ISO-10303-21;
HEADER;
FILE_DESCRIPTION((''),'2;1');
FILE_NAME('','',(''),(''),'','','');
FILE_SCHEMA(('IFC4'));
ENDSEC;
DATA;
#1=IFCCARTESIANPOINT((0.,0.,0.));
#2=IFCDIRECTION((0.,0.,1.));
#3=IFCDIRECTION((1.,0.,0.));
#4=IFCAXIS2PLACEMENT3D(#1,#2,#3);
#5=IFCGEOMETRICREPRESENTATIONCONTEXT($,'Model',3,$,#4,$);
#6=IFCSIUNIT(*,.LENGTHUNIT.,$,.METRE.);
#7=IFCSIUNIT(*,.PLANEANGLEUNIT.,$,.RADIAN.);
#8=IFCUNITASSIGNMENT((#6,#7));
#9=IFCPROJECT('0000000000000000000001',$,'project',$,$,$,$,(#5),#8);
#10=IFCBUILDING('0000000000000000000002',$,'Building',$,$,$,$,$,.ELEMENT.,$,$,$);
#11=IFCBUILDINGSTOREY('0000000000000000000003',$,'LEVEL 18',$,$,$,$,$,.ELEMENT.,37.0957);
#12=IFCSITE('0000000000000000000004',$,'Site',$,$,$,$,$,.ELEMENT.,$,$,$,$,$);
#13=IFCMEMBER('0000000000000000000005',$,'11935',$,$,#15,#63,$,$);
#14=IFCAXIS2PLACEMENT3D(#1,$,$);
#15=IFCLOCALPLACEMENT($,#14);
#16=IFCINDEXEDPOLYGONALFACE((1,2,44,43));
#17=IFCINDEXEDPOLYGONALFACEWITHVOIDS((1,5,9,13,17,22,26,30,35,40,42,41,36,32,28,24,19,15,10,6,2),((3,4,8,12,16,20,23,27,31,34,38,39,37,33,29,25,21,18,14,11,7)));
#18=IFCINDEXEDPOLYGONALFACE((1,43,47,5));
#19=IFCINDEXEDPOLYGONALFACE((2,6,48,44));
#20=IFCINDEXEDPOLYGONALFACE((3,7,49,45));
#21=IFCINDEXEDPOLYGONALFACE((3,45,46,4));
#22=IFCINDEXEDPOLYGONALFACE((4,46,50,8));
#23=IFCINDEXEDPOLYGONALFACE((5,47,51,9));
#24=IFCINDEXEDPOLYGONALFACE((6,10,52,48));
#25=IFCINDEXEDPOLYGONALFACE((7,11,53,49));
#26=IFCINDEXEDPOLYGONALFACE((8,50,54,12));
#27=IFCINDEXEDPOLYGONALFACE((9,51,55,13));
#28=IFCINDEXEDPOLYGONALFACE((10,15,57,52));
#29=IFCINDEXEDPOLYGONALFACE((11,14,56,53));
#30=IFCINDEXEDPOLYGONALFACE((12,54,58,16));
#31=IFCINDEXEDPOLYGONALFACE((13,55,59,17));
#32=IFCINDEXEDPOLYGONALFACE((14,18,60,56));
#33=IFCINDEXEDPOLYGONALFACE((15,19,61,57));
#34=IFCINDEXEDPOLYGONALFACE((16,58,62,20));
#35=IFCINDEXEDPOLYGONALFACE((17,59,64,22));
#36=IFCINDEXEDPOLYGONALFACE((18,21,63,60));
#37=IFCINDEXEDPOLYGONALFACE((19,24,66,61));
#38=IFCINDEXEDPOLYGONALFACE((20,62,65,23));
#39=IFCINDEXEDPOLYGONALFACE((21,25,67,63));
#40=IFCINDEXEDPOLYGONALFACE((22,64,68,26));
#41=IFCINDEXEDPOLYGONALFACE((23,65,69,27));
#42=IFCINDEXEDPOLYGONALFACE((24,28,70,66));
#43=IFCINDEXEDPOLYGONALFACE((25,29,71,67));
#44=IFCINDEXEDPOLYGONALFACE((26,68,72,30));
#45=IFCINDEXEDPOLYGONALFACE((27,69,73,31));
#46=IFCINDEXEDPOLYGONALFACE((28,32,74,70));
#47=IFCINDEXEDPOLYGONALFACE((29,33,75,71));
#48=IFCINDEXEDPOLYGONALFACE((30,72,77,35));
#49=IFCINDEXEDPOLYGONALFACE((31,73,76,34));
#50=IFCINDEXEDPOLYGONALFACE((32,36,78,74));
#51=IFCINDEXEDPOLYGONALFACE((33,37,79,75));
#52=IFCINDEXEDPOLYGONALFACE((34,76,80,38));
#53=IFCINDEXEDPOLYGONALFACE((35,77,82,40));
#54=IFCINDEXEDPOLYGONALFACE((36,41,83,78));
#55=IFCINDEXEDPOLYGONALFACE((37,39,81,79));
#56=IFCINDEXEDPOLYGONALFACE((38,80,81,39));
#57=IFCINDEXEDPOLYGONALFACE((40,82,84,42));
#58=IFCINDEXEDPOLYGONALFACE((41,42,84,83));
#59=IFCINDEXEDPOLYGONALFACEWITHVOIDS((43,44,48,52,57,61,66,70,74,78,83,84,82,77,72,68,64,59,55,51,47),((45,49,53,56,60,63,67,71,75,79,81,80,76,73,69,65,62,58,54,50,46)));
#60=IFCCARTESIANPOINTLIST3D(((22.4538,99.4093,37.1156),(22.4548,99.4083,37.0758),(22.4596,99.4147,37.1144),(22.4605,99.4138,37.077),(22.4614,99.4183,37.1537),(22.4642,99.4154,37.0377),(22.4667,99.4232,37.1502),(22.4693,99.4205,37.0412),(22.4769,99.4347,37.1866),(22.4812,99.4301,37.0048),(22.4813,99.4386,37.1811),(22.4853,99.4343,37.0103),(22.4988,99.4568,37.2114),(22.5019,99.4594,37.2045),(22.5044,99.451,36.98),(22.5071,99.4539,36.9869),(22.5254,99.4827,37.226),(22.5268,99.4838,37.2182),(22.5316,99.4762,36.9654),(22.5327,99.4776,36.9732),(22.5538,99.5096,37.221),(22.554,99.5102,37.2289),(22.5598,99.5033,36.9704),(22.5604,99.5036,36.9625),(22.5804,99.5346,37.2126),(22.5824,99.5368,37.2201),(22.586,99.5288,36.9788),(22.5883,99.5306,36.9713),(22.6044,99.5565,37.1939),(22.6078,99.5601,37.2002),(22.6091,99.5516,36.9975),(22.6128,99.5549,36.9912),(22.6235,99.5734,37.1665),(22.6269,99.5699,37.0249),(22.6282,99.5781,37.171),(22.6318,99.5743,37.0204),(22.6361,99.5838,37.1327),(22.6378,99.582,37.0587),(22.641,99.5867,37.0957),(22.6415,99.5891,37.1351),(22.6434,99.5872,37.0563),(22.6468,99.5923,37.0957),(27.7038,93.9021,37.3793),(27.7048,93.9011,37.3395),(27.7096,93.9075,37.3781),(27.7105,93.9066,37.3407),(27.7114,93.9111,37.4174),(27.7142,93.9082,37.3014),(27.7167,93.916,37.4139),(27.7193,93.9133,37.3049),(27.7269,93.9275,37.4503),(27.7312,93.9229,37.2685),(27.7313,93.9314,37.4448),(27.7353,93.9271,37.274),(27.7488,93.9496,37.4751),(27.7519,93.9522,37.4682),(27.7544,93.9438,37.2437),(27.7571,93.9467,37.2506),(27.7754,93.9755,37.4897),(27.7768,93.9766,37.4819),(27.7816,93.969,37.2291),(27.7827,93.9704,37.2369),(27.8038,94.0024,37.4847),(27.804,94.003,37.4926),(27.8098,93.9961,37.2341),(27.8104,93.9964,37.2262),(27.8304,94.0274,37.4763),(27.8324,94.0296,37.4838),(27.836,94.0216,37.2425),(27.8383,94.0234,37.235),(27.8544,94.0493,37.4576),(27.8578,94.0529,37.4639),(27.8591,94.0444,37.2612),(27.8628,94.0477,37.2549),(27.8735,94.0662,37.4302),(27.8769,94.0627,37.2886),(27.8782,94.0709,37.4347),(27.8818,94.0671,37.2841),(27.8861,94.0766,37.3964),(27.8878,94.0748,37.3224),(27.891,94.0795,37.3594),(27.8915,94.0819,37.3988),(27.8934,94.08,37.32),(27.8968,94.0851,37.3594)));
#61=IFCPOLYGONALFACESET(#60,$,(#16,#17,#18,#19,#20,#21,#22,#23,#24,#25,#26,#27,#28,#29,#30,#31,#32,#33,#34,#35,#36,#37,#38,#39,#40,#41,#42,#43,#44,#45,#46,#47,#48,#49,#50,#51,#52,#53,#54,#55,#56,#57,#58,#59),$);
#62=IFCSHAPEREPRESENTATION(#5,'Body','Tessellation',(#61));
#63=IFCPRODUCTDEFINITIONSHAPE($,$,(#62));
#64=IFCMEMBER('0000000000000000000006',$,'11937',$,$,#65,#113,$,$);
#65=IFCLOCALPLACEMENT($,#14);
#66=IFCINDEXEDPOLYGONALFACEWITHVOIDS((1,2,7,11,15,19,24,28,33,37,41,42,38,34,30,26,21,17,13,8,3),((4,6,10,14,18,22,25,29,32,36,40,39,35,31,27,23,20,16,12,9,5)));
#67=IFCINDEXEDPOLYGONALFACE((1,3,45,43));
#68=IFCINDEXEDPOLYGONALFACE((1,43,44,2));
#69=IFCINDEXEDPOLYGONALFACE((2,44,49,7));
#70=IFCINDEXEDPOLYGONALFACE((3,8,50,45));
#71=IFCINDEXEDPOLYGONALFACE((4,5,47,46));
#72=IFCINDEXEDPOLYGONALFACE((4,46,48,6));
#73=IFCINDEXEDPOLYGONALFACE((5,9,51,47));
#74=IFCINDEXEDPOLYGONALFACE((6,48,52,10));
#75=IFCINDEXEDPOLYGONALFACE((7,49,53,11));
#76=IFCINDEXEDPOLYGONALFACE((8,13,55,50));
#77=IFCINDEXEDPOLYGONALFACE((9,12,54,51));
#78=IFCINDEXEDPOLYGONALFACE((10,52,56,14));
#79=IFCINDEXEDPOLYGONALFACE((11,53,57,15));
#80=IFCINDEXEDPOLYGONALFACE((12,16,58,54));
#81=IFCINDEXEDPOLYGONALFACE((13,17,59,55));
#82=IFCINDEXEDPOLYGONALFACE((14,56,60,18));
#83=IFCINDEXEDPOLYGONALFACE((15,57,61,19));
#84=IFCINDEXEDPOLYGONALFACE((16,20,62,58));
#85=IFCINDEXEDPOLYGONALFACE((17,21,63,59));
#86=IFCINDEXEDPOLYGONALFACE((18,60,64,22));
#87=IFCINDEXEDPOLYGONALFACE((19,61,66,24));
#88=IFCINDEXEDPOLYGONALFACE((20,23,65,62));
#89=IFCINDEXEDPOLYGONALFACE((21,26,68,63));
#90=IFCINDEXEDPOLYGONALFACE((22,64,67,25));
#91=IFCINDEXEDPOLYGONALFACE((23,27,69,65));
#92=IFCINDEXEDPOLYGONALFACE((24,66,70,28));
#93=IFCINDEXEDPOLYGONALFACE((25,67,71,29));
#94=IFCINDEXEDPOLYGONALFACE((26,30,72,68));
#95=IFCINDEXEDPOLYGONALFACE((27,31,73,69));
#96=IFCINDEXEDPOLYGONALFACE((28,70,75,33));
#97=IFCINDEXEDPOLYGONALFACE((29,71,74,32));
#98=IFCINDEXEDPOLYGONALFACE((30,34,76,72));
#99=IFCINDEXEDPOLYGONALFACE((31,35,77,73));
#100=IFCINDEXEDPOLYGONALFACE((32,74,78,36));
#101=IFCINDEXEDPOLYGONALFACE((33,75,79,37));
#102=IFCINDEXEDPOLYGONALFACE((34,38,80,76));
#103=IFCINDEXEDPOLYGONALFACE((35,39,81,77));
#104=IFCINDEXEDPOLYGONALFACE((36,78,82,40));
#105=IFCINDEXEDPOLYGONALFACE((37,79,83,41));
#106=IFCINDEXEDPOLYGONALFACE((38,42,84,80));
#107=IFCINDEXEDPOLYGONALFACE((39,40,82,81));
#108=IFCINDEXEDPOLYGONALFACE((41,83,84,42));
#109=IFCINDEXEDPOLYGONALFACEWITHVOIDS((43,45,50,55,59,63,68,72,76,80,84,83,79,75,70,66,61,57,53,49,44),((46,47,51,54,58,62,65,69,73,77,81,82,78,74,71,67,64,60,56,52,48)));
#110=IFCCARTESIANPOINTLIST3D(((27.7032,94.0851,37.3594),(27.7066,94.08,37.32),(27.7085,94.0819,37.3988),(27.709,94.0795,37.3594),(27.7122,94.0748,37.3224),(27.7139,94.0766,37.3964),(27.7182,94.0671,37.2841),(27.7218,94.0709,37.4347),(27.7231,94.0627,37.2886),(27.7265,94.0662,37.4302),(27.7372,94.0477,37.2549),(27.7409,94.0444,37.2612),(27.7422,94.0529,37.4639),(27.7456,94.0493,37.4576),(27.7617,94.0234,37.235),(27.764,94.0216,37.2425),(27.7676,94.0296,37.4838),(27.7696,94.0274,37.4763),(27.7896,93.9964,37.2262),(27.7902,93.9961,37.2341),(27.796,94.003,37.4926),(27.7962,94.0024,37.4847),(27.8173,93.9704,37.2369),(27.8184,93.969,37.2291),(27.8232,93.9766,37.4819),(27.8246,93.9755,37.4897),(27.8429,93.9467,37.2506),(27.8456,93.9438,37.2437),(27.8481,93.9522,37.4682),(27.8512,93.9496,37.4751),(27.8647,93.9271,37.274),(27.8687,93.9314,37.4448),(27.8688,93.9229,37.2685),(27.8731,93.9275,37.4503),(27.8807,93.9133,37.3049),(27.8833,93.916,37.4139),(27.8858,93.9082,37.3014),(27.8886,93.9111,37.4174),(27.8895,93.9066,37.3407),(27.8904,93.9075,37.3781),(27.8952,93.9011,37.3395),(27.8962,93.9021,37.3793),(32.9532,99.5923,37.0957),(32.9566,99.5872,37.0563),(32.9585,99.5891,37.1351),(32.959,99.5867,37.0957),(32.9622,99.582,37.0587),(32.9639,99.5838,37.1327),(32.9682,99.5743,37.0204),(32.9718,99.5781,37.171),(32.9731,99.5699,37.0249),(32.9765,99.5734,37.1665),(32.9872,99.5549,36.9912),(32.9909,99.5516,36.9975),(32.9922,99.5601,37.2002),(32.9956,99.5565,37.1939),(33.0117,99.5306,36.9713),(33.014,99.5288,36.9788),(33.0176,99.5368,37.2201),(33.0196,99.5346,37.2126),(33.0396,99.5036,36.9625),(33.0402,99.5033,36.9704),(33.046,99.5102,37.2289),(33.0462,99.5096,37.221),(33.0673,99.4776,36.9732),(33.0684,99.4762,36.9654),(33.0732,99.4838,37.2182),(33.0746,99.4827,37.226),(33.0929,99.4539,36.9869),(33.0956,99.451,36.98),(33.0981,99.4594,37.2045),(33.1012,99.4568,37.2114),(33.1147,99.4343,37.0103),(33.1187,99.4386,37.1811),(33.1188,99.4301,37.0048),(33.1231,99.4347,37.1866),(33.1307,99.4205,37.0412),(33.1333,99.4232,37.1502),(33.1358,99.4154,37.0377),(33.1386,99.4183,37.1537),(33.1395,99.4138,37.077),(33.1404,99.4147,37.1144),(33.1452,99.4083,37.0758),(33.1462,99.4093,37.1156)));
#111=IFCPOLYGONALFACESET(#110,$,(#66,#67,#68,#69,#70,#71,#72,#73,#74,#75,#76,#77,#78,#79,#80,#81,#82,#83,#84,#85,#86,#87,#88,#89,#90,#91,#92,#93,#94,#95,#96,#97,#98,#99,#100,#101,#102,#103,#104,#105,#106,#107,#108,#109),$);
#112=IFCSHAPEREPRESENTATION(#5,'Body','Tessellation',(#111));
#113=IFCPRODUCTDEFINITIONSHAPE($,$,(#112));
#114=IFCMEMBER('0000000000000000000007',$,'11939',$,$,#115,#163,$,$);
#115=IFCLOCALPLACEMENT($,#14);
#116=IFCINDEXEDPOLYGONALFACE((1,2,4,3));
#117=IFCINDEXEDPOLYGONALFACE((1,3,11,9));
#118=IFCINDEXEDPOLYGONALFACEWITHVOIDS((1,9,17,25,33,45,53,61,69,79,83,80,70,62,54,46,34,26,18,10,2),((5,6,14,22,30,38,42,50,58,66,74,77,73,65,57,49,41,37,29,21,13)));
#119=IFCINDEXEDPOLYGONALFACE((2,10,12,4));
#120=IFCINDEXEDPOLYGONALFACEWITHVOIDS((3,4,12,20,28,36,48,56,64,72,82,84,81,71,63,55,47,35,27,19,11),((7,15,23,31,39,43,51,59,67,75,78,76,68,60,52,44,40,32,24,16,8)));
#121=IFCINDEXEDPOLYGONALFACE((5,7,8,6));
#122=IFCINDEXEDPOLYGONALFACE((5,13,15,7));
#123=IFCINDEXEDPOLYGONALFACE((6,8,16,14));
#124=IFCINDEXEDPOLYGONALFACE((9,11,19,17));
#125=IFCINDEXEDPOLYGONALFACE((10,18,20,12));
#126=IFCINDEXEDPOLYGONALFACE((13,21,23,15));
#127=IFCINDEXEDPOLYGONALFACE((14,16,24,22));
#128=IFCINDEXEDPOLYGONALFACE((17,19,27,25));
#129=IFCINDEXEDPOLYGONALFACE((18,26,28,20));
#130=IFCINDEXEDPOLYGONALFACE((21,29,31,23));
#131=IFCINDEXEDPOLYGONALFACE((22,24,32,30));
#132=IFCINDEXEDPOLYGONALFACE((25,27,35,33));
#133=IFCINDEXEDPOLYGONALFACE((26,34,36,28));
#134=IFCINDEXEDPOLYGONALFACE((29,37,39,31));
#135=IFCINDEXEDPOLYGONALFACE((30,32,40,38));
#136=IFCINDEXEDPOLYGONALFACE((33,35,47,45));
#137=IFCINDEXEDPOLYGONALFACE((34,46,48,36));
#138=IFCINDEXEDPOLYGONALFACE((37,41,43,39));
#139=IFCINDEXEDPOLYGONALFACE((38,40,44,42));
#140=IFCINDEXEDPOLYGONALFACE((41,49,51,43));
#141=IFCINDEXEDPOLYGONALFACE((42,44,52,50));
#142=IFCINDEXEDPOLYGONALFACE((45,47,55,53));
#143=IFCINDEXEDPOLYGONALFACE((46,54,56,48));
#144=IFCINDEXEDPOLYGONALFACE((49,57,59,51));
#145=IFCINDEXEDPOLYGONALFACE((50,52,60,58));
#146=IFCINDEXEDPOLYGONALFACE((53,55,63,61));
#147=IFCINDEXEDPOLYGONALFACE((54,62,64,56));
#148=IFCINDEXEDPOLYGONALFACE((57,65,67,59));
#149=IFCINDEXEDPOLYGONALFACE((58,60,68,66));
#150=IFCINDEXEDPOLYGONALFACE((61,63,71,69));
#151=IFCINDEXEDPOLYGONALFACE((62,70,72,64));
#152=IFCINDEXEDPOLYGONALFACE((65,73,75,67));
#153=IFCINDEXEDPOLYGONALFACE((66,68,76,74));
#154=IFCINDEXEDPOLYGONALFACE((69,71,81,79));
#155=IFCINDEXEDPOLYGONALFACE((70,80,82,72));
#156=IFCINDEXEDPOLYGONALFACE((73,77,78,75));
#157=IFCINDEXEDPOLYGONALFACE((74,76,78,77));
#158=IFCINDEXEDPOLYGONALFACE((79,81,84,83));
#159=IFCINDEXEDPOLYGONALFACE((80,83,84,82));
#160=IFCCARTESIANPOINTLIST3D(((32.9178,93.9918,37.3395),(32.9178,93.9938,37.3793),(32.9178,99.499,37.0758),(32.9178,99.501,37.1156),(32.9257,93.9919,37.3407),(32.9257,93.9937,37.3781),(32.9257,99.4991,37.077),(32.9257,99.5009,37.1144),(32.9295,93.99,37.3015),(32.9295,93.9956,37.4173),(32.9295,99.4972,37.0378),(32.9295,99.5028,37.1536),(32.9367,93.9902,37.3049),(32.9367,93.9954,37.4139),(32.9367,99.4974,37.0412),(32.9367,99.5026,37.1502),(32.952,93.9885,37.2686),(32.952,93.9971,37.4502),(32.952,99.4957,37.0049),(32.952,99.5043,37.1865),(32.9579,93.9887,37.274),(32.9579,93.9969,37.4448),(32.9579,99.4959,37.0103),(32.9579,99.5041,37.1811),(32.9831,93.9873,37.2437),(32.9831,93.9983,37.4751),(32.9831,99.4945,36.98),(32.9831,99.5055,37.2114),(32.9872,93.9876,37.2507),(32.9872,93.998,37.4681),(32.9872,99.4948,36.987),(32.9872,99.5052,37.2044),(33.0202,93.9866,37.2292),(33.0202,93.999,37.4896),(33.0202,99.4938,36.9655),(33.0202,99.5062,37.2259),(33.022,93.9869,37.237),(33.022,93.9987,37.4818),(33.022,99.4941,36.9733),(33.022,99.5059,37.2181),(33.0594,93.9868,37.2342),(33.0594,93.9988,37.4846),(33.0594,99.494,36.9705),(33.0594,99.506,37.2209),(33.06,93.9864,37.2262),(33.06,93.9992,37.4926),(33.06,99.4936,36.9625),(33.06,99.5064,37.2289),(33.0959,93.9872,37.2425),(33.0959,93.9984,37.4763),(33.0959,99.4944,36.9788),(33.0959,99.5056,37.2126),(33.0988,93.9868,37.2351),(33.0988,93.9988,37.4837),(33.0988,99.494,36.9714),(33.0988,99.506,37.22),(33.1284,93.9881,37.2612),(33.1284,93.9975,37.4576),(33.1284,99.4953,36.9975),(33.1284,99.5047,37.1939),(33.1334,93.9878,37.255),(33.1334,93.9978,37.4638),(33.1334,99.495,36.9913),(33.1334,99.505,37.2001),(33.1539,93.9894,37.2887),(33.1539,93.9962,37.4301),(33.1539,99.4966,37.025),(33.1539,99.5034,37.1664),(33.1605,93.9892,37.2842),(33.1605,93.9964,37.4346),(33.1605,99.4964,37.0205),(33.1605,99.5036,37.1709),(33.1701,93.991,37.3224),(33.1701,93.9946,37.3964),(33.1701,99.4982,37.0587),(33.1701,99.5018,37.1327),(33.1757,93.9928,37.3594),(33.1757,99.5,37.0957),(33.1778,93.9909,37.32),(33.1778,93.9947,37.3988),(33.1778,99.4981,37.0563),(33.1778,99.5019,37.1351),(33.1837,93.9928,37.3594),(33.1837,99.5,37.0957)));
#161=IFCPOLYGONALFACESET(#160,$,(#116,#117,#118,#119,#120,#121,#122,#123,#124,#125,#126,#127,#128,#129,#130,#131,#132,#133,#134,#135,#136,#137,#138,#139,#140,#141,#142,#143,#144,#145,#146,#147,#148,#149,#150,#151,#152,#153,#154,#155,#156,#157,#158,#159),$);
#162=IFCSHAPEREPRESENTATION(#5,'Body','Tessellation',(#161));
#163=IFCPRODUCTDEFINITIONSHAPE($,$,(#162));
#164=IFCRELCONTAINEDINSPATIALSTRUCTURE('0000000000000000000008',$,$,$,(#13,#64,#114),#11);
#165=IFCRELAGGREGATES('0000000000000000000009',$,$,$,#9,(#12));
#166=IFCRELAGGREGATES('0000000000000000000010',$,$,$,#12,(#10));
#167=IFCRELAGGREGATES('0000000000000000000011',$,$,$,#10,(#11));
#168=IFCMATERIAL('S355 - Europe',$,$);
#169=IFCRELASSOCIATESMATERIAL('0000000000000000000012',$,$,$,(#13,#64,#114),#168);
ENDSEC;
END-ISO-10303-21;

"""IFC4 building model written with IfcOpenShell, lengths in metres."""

from ifc_helpers import new_model, si_unit, frame, origin_with_axes, origin_2d_with_axis, place, context, project, spatial, hollow_circle, extrude, material, material_profile, profile_set, profile_usage, element, save


model = new_model("IFC4")

# Units and contexts
model_context = context("Model", 3, world=origin_with_axes())
ifc_project = project(units=[si_unit("LENGTHUNIT", "METRE"), si_unit("PLANEANGLEUNIT", "RADIAN")], contexts=[model_context])

# Site, building, storey
site = spatial("IfcSite", under=ifc_project, Name="Site", CompositionType="ELEMENT")
building = spatial("IfcBuilding", under=site, Name="Building", CompositionType="ELEMENT")
storey = spatial("IfcBuildingStorey", under=building, Name="LEVEL 18", CompositionType="ELEMENT", Elevation=37.0957)

# Shared definitions
ifc_material = material(Name="S355 - Europe")

# Members
ifc_material_profile_1 = material_profile(ifc_material, hollow_circle(Radius=0.1337, WallThickness=0.008, at=origin_2d_with_axis()))
ifc_profile_set_1 = profile_set([ifc_material_profile_1])
ifc_profile_usage_1 = profile_usage(ifc_profile_set_1, cardinal=10)
member_1_placement = place(None, frame((22.55, 99.5, 37.0957), z_axis=(0.689589, -0.723372, 0.034637), x_axis=(0.723807, 0.690003, 0.0)))
element("IfcMember", 1, at=member_1_placement, inside=storey, material=ifc_profile_usage_1, Name="11935", context=model_context, shape_type="SweptSolid", body=[
    extrude(hollow_circle(Radius=0.1337, WallThickness=0.008, at=origin_2d_with_axis()), origin_with_axes(), (0.0, 0.0, 1.0), 7.6132),
])
ifc_material_profile_2 = material_profile(ifc_material, hollow_circle(Radius=0.1337, WallThickness=0.008, at=origin_2d_with_axis()))
ifc_profile_set_2 = profile_set([ifc_material_profile_2])
ifc_profile_usage_2 = profile_usage(ifc_profile_set_2, cardinal=10)
member_2_placement = place(None, frame((27.8, 93.9928, 37.3594), z_axis=(0.689589, 0.723372, -0.034637), x_axis=(-0.723807, 0.690003, 0.0)))
element("IfcMember", 2, at=member_2_placement, inside=storey, material=ifc_profile_usage_2, Name="11937", context=model_context, shape_type="SweptSolid", body=[
    extrude(hollow_circle(Radius=0.1337, WallThickness=0.008, at=origin_2d_with_axis()), origin_with_axes(), (0.0, 0.0, 1.0), 7.6132),
])
ifc_material_profile_3 = material_profile(ifc_material, hollow_circle(Radius=0.1337, WallThickness=0.008, at=origin_2d_with_axis()))
ifc_profile_set_3 = profile_set([ifc_material_profile_3])
ifc_profile_usage_3 = profile_usage(ifc_profile_set_3, cardinal=10)
member_3_placement = place(None, frame((33.05, 99.5, 37.0957), z_axis=(0.0, -0.998856, 0.047828), x_axis=(1.0, 0.0, 0.0)))
element("IfcMember", 3, at=member_3_placement, inside=storey, material=ifc_profile_usage_3, Name="11939", context=model_context, shape_type="SweptSolid", body=[
    extrude(hollow_circle(Radius=0.1337, WallThickness=0.008, at=origin_2d_with_axis()), origin_with_axes(), (0.0, 0.0, 1.0), 5.5135),
])

save(model, "model.ifc")
